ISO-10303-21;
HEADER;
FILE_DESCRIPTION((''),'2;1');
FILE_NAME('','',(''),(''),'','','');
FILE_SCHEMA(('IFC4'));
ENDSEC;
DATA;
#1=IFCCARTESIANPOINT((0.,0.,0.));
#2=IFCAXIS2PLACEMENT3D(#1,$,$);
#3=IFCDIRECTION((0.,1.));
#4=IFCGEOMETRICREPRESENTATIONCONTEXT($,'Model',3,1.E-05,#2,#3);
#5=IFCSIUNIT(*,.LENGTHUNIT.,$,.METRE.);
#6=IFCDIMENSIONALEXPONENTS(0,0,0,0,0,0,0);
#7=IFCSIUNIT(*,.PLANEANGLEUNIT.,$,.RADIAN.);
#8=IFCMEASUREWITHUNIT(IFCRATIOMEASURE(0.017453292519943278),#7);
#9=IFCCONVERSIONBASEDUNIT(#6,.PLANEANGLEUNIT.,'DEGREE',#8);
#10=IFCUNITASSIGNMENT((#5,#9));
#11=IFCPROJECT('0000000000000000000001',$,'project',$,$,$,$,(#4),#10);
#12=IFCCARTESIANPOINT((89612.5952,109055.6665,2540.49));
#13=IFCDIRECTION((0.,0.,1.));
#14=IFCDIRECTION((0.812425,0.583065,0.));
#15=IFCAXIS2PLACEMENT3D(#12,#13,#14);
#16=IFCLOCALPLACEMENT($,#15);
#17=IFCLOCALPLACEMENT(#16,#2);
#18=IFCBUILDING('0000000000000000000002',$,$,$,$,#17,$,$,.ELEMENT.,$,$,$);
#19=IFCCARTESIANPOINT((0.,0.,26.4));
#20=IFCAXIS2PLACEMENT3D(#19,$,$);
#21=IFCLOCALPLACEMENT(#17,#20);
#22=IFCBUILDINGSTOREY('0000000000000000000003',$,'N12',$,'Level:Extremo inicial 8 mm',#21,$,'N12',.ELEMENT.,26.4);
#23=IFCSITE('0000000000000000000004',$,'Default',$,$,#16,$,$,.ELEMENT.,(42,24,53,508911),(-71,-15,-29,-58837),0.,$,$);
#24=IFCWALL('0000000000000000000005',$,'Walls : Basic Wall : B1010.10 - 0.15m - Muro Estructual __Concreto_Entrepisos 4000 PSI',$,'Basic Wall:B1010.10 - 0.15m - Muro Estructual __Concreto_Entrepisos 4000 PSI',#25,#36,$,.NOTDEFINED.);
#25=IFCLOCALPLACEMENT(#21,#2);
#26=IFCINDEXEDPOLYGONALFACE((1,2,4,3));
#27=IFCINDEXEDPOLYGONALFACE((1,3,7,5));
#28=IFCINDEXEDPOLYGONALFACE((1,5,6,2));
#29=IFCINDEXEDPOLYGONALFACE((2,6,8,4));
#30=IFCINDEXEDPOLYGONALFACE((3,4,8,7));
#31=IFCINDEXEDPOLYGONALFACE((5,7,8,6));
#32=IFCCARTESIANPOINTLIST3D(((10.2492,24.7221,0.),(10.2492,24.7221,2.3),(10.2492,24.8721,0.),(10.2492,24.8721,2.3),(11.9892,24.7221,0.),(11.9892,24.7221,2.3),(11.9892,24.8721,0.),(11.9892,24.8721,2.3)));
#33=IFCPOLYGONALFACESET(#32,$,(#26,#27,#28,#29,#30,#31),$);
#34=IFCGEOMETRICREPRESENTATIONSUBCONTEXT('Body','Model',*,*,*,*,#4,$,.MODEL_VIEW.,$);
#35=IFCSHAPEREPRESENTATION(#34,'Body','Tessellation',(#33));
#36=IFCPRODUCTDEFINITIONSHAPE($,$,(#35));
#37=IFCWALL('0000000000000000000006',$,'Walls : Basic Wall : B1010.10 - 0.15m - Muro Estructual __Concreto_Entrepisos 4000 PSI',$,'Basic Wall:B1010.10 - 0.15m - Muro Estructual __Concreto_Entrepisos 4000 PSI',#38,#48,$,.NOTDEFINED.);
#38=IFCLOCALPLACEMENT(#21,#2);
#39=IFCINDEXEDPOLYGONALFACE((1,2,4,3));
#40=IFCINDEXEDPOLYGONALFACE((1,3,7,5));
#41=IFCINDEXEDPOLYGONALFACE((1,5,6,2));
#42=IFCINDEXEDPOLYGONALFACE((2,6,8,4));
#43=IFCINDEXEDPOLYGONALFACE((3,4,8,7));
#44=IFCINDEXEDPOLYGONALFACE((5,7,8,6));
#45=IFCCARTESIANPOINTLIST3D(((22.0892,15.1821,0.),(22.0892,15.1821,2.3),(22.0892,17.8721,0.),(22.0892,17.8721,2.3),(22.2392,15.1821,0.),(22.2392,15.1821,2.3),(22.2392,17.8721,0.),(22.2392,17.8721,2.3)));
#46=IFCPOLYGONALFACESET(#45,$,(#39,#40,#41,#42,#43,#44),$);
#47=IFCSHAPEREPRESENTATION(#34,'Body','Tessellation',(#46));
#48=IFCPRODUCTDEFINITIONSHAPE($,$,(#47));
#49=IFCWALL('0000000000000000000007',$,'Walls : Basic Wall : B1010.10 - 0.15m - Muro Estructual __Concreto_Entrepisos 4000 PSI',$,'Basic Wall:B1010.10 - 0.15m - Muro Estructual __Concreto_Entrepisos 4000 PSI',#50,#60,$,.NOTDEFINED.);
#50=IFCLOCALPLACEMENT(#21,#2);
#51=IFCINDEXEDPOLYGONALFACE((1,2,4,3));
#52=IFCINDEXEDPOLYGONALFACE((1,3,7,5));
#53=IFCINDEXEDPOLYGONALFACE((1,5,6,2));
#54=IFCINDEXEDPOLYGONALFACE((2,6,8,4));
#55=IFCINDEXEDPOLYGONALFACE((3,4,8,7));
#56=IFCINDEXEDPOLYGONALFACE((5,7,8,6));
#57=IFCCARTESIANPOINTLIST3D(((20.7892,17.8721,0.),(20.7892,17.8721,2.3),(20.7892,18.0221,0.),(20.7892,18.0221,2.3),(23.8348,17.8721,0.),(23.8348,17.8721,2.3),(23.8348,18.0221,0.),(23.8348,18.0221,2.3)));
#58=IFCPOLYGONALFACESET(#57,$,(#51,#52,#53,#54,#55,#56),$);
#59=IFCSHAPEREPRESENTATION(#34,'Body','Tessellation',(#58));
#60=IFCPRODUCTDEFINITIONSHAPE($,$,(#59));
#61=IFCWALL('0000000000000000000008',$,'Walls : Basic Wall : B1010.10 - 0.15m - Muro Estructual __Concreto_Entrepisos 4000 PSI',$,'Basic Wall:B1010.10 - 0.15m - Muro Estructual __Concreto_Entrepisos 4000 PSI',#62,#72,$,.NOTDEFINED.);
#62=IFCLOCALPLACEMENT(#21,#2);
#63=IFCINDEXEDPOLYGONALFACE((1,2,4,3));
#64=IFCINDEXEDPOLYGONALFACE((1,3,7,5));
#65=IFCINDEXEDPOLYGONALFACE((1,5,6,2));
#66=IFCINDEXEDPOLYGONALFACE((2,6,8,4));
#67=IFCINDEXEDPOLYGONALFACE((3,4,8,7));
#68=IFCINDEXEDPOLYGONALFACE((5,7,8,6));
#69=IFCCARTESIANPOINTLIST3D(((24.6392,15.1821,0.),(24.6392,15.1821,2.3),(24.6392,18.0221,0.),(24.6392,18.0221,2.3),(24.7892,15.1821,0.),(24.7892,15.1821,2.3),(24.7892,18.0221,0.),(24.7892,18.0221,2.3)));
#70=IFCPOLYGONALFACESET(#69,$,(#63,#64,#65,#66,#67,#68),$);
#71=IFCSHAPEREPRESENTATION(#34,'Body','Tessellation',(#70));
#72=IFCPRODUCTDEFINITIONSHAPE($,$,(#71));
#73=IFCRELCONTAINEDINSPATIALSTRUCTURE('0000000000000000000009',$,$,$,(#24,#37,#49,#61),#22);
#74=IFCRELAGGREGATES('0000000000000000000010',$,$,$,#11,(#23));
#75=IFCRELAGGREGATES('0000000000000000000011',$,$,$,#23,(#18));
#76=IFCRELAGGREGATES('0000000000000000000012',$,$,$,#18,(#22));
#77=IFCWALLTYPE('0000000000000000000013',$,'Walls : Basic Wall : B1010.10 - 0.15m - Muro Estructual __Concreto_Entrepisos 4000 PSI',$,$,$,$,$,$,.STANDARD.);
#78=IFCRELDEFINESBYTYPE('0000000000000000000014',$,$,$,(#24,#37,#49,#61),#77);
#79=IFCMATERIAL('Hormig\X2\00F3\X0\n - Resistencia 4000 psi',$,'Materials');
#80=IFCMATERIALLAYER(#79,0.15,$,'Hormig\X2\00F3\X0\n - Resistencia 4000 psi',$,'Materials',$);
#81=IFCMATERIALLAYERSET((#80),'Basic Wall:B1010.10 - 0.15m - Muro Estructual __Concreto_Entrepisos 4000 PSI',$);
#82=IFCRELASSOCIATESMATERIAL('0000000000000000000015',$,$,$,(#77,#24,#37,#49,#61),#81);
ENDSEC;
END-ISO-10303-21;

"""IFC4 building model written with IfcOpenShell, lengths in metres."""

from ifc_helpers import new_model, entity, si_unit, converted_unit, direction, frame, frame_2d, origin, place, context, subcontext, project, spatial, rectangle, extrude, material, layer, layer_set, layer_usage, type_object, element, save


model = new_model("IFC4")

# Units and contexts
model_context = context("Model", 3, precision=1e-05, world=origin(), true_north=direction((0.0, 1.0)))
body_context = subcontext(model_context, "Body", "Model", "MODEL_VIEW")
ifc_project = project(units=[si_unit("LENGTHUNIT", "METRE"), converted_unit("PLANEANGLEUNIT", "DEGREE", entity("IfcRatioMeasure", 0.017453292519943278), si_unit("PLANEANGLEUNIT", "RADIAN"), dimensions=[0, 0, 0, 0, 0, 0, 0])], contexts=[model_context])

# Site, building, storey
site_placement = place(None, frame((89612.5952, 109055.6665, 2540.49), z_axis=(0.0, 0.0, 1.0), x_axis=(0.812425, 0.583065, 0.0)))
site = spatial("IfcSite", under=ifc_project, at=site_placement, Name="Default", CompositionType="ELEMENT", RefLatitude=(42, 24, 53, 508911), RefLongitude=(-71, -15, -29, -58837), RefElevation=0.0)
building_placement = place(site_placement, origin())
building = spatial("IfcBuilding", under=site, at=building_placement, CompositionType="ELEMENT")
storey_placement = place(building_placement, frame((0.0, 0.0, 26.4)))
storey = spatial("IfcBuildingStorey", under=building, at=storey_placement, Name="N12", ObjectType="Level:Extremo inicial 8 mm", LongName="N12", CompositionType="ELEMENT", Elevation=26.4)

# Walls
ifc_material = material(Name="Hormigón - Resistencia 4000 psi", Category="Materials")
ifc_layer_1 = layer(ifc_material, 0.15, Name="Hormigón - Resistencia 4000 psi", Category="Materials")
ifc_layer_set_1 = layer_set([ifc_layer_1], Name="Basic Wall:B1010.10 - 0.15m - Muro Estructual __Concreto_Entrepisos 4000 PSI")
wall_type_1 = type_object("IfcWallType", Name="Walls : Basic Wall : B1010.10 - 0.15m - Muro Estructual __Concreto_Entrepisos 4000 PSI", PredefinedType="STANDARD", material=ifc_layer_set_1)
ifc_layer_usage_1 = layer_usage(ifc_layer_set_1, "AXIS2", "POSITIVE", -0.075)
wall_1_placement = place(storey_placement, frame((11.9892, 24.7971, 0.0), z_axis=(0.0, 0.0, 1.0), x_axis=(-1.0, 0.0, 0.0)))
element("IfcWall", 1, at=wall_1_placement, inside=storey, type_object=wall_type_1, material=ifc_layer_usage_1, Name="Walls : Basic Wall : B1010.10 - 0.15m - Muro Estructual __Concreto_Entrepisos 4000 PSI", ObjectType="Basic Wall:B1010.10 - 0.15m - Muro Estructual __Concreto_Entrepisos 4000 PSI", PredefinedType="NOTDEFINED", context=body_context, shape_type="SweptSolid", body=[
    extrude(rectangle(XDim=1.74, YDim=0.15, at=frame_2d((0.87, 0.0), x_axis=(-1.0, 0.0))), origin(), (0.0, 0.0, 1.0), 2.3),
])
ifc_layer_usage_2 = layer_usage(ifc_layer_set_1, "AXIS2", "POSITIVE", -0.075)
wall_2_placement = place(storey_placement, frame((22.1642, 15.1821, 0.0), z_axis=(0.0, 0.0, 1.0), x_axis=(0.0, 1.0, 0.0)))
element("IfcWall", 2, at=wall_2_placement, inside=storey, type_object=wall_type_1, material=ifc_layer_usage_2, Name="Walls : Basic Wall : B1010.10 - 0.15m - Muro Estructual __Concreto_Entrepisos 4000 PSI", ObjectType="Basic Wall:B1010.10 - 0.15m - Muro Estructual __Concreto_Entrepisos 4000 PSI", PredefinedType="NOTDEFINED", context=body_context, shape_type="SweptSolid", body=[
    extrude(rectangle(XDim=2.69, YDim=0.15, at=frame_2d((1.345, 0.0), x_axis=(-1.0, 0.0))), origin(), (0.0, 0.0, 1.0), 2.3),
])
ifc_layer_usage_3 = layer_usage(ifc_layer_set_1, "AXIS2", "POSITIVE", -0.075)
wall_3_placement = place(storey_placement, frame((20.7892, 17.9471, 0.0)))
element("IfcWall", 3, at=wall_3_placement, inside=storey, type_object=wall_type_1, material=ifc_layer_usage_3, Name="Walls : Basic Wall : B1010.10 - 0.15m - Muro Estructual __Concreto_Entrepisos 4000 PSI", ObjectType="Basic Wall:B1010.10 - 0.15m - Muro Estructual __Concreto_Entrepisos 4000 PSI", PredefinedType="NOTDEFINED", context=body_context, shape_type="SweptSolid", body=[
    extrude(rectangle(XDim=3.0455, YDim=0.15, at=frame_2d((1.5228, 0.0), x_axis=(-1.0, 0.0))), origin(), (0.0, 0.0, 1.0), 2.3),
])
ifc_layer_usage_4 = layer_usage(ifc_layer_set_1, "AXIS2", "POSITIVE", -0.075)
wall_4_placement = place(storey_placement, frame((24.7142, 15.1821, 0.0), z_axis=(0.0, 0.0, 1.0), x_axis=(0.0, 1.0, 0.0)))
element("IfcWall", 4, at=wall_4_placement, inside=storey, type_object=wall_type_1, material=ifc_layer_usage_4, Name="Walls : Basic Wall : B1010.10 - 0.15m - Muro Estructual __Concreto_Entrepisos 4000 PSI", ObjectType="Basic Wall:B1010.10 - 0.15m - Muro Estructual __Concreto_Entrepisos 4000 PSI", PredefinedType="NOTDEFINED", context=body_context, shape_type="SweptSolid", body=[
    extrude(rectangle(XDim=2.84, YDim=0.15, at=frame_2d((1.42, 0.0), x_axis=(-1.0, 0.0))), origin(), (0.0, 0.0, 1.0), 2.3),
])

save(model, "model.ifc")
